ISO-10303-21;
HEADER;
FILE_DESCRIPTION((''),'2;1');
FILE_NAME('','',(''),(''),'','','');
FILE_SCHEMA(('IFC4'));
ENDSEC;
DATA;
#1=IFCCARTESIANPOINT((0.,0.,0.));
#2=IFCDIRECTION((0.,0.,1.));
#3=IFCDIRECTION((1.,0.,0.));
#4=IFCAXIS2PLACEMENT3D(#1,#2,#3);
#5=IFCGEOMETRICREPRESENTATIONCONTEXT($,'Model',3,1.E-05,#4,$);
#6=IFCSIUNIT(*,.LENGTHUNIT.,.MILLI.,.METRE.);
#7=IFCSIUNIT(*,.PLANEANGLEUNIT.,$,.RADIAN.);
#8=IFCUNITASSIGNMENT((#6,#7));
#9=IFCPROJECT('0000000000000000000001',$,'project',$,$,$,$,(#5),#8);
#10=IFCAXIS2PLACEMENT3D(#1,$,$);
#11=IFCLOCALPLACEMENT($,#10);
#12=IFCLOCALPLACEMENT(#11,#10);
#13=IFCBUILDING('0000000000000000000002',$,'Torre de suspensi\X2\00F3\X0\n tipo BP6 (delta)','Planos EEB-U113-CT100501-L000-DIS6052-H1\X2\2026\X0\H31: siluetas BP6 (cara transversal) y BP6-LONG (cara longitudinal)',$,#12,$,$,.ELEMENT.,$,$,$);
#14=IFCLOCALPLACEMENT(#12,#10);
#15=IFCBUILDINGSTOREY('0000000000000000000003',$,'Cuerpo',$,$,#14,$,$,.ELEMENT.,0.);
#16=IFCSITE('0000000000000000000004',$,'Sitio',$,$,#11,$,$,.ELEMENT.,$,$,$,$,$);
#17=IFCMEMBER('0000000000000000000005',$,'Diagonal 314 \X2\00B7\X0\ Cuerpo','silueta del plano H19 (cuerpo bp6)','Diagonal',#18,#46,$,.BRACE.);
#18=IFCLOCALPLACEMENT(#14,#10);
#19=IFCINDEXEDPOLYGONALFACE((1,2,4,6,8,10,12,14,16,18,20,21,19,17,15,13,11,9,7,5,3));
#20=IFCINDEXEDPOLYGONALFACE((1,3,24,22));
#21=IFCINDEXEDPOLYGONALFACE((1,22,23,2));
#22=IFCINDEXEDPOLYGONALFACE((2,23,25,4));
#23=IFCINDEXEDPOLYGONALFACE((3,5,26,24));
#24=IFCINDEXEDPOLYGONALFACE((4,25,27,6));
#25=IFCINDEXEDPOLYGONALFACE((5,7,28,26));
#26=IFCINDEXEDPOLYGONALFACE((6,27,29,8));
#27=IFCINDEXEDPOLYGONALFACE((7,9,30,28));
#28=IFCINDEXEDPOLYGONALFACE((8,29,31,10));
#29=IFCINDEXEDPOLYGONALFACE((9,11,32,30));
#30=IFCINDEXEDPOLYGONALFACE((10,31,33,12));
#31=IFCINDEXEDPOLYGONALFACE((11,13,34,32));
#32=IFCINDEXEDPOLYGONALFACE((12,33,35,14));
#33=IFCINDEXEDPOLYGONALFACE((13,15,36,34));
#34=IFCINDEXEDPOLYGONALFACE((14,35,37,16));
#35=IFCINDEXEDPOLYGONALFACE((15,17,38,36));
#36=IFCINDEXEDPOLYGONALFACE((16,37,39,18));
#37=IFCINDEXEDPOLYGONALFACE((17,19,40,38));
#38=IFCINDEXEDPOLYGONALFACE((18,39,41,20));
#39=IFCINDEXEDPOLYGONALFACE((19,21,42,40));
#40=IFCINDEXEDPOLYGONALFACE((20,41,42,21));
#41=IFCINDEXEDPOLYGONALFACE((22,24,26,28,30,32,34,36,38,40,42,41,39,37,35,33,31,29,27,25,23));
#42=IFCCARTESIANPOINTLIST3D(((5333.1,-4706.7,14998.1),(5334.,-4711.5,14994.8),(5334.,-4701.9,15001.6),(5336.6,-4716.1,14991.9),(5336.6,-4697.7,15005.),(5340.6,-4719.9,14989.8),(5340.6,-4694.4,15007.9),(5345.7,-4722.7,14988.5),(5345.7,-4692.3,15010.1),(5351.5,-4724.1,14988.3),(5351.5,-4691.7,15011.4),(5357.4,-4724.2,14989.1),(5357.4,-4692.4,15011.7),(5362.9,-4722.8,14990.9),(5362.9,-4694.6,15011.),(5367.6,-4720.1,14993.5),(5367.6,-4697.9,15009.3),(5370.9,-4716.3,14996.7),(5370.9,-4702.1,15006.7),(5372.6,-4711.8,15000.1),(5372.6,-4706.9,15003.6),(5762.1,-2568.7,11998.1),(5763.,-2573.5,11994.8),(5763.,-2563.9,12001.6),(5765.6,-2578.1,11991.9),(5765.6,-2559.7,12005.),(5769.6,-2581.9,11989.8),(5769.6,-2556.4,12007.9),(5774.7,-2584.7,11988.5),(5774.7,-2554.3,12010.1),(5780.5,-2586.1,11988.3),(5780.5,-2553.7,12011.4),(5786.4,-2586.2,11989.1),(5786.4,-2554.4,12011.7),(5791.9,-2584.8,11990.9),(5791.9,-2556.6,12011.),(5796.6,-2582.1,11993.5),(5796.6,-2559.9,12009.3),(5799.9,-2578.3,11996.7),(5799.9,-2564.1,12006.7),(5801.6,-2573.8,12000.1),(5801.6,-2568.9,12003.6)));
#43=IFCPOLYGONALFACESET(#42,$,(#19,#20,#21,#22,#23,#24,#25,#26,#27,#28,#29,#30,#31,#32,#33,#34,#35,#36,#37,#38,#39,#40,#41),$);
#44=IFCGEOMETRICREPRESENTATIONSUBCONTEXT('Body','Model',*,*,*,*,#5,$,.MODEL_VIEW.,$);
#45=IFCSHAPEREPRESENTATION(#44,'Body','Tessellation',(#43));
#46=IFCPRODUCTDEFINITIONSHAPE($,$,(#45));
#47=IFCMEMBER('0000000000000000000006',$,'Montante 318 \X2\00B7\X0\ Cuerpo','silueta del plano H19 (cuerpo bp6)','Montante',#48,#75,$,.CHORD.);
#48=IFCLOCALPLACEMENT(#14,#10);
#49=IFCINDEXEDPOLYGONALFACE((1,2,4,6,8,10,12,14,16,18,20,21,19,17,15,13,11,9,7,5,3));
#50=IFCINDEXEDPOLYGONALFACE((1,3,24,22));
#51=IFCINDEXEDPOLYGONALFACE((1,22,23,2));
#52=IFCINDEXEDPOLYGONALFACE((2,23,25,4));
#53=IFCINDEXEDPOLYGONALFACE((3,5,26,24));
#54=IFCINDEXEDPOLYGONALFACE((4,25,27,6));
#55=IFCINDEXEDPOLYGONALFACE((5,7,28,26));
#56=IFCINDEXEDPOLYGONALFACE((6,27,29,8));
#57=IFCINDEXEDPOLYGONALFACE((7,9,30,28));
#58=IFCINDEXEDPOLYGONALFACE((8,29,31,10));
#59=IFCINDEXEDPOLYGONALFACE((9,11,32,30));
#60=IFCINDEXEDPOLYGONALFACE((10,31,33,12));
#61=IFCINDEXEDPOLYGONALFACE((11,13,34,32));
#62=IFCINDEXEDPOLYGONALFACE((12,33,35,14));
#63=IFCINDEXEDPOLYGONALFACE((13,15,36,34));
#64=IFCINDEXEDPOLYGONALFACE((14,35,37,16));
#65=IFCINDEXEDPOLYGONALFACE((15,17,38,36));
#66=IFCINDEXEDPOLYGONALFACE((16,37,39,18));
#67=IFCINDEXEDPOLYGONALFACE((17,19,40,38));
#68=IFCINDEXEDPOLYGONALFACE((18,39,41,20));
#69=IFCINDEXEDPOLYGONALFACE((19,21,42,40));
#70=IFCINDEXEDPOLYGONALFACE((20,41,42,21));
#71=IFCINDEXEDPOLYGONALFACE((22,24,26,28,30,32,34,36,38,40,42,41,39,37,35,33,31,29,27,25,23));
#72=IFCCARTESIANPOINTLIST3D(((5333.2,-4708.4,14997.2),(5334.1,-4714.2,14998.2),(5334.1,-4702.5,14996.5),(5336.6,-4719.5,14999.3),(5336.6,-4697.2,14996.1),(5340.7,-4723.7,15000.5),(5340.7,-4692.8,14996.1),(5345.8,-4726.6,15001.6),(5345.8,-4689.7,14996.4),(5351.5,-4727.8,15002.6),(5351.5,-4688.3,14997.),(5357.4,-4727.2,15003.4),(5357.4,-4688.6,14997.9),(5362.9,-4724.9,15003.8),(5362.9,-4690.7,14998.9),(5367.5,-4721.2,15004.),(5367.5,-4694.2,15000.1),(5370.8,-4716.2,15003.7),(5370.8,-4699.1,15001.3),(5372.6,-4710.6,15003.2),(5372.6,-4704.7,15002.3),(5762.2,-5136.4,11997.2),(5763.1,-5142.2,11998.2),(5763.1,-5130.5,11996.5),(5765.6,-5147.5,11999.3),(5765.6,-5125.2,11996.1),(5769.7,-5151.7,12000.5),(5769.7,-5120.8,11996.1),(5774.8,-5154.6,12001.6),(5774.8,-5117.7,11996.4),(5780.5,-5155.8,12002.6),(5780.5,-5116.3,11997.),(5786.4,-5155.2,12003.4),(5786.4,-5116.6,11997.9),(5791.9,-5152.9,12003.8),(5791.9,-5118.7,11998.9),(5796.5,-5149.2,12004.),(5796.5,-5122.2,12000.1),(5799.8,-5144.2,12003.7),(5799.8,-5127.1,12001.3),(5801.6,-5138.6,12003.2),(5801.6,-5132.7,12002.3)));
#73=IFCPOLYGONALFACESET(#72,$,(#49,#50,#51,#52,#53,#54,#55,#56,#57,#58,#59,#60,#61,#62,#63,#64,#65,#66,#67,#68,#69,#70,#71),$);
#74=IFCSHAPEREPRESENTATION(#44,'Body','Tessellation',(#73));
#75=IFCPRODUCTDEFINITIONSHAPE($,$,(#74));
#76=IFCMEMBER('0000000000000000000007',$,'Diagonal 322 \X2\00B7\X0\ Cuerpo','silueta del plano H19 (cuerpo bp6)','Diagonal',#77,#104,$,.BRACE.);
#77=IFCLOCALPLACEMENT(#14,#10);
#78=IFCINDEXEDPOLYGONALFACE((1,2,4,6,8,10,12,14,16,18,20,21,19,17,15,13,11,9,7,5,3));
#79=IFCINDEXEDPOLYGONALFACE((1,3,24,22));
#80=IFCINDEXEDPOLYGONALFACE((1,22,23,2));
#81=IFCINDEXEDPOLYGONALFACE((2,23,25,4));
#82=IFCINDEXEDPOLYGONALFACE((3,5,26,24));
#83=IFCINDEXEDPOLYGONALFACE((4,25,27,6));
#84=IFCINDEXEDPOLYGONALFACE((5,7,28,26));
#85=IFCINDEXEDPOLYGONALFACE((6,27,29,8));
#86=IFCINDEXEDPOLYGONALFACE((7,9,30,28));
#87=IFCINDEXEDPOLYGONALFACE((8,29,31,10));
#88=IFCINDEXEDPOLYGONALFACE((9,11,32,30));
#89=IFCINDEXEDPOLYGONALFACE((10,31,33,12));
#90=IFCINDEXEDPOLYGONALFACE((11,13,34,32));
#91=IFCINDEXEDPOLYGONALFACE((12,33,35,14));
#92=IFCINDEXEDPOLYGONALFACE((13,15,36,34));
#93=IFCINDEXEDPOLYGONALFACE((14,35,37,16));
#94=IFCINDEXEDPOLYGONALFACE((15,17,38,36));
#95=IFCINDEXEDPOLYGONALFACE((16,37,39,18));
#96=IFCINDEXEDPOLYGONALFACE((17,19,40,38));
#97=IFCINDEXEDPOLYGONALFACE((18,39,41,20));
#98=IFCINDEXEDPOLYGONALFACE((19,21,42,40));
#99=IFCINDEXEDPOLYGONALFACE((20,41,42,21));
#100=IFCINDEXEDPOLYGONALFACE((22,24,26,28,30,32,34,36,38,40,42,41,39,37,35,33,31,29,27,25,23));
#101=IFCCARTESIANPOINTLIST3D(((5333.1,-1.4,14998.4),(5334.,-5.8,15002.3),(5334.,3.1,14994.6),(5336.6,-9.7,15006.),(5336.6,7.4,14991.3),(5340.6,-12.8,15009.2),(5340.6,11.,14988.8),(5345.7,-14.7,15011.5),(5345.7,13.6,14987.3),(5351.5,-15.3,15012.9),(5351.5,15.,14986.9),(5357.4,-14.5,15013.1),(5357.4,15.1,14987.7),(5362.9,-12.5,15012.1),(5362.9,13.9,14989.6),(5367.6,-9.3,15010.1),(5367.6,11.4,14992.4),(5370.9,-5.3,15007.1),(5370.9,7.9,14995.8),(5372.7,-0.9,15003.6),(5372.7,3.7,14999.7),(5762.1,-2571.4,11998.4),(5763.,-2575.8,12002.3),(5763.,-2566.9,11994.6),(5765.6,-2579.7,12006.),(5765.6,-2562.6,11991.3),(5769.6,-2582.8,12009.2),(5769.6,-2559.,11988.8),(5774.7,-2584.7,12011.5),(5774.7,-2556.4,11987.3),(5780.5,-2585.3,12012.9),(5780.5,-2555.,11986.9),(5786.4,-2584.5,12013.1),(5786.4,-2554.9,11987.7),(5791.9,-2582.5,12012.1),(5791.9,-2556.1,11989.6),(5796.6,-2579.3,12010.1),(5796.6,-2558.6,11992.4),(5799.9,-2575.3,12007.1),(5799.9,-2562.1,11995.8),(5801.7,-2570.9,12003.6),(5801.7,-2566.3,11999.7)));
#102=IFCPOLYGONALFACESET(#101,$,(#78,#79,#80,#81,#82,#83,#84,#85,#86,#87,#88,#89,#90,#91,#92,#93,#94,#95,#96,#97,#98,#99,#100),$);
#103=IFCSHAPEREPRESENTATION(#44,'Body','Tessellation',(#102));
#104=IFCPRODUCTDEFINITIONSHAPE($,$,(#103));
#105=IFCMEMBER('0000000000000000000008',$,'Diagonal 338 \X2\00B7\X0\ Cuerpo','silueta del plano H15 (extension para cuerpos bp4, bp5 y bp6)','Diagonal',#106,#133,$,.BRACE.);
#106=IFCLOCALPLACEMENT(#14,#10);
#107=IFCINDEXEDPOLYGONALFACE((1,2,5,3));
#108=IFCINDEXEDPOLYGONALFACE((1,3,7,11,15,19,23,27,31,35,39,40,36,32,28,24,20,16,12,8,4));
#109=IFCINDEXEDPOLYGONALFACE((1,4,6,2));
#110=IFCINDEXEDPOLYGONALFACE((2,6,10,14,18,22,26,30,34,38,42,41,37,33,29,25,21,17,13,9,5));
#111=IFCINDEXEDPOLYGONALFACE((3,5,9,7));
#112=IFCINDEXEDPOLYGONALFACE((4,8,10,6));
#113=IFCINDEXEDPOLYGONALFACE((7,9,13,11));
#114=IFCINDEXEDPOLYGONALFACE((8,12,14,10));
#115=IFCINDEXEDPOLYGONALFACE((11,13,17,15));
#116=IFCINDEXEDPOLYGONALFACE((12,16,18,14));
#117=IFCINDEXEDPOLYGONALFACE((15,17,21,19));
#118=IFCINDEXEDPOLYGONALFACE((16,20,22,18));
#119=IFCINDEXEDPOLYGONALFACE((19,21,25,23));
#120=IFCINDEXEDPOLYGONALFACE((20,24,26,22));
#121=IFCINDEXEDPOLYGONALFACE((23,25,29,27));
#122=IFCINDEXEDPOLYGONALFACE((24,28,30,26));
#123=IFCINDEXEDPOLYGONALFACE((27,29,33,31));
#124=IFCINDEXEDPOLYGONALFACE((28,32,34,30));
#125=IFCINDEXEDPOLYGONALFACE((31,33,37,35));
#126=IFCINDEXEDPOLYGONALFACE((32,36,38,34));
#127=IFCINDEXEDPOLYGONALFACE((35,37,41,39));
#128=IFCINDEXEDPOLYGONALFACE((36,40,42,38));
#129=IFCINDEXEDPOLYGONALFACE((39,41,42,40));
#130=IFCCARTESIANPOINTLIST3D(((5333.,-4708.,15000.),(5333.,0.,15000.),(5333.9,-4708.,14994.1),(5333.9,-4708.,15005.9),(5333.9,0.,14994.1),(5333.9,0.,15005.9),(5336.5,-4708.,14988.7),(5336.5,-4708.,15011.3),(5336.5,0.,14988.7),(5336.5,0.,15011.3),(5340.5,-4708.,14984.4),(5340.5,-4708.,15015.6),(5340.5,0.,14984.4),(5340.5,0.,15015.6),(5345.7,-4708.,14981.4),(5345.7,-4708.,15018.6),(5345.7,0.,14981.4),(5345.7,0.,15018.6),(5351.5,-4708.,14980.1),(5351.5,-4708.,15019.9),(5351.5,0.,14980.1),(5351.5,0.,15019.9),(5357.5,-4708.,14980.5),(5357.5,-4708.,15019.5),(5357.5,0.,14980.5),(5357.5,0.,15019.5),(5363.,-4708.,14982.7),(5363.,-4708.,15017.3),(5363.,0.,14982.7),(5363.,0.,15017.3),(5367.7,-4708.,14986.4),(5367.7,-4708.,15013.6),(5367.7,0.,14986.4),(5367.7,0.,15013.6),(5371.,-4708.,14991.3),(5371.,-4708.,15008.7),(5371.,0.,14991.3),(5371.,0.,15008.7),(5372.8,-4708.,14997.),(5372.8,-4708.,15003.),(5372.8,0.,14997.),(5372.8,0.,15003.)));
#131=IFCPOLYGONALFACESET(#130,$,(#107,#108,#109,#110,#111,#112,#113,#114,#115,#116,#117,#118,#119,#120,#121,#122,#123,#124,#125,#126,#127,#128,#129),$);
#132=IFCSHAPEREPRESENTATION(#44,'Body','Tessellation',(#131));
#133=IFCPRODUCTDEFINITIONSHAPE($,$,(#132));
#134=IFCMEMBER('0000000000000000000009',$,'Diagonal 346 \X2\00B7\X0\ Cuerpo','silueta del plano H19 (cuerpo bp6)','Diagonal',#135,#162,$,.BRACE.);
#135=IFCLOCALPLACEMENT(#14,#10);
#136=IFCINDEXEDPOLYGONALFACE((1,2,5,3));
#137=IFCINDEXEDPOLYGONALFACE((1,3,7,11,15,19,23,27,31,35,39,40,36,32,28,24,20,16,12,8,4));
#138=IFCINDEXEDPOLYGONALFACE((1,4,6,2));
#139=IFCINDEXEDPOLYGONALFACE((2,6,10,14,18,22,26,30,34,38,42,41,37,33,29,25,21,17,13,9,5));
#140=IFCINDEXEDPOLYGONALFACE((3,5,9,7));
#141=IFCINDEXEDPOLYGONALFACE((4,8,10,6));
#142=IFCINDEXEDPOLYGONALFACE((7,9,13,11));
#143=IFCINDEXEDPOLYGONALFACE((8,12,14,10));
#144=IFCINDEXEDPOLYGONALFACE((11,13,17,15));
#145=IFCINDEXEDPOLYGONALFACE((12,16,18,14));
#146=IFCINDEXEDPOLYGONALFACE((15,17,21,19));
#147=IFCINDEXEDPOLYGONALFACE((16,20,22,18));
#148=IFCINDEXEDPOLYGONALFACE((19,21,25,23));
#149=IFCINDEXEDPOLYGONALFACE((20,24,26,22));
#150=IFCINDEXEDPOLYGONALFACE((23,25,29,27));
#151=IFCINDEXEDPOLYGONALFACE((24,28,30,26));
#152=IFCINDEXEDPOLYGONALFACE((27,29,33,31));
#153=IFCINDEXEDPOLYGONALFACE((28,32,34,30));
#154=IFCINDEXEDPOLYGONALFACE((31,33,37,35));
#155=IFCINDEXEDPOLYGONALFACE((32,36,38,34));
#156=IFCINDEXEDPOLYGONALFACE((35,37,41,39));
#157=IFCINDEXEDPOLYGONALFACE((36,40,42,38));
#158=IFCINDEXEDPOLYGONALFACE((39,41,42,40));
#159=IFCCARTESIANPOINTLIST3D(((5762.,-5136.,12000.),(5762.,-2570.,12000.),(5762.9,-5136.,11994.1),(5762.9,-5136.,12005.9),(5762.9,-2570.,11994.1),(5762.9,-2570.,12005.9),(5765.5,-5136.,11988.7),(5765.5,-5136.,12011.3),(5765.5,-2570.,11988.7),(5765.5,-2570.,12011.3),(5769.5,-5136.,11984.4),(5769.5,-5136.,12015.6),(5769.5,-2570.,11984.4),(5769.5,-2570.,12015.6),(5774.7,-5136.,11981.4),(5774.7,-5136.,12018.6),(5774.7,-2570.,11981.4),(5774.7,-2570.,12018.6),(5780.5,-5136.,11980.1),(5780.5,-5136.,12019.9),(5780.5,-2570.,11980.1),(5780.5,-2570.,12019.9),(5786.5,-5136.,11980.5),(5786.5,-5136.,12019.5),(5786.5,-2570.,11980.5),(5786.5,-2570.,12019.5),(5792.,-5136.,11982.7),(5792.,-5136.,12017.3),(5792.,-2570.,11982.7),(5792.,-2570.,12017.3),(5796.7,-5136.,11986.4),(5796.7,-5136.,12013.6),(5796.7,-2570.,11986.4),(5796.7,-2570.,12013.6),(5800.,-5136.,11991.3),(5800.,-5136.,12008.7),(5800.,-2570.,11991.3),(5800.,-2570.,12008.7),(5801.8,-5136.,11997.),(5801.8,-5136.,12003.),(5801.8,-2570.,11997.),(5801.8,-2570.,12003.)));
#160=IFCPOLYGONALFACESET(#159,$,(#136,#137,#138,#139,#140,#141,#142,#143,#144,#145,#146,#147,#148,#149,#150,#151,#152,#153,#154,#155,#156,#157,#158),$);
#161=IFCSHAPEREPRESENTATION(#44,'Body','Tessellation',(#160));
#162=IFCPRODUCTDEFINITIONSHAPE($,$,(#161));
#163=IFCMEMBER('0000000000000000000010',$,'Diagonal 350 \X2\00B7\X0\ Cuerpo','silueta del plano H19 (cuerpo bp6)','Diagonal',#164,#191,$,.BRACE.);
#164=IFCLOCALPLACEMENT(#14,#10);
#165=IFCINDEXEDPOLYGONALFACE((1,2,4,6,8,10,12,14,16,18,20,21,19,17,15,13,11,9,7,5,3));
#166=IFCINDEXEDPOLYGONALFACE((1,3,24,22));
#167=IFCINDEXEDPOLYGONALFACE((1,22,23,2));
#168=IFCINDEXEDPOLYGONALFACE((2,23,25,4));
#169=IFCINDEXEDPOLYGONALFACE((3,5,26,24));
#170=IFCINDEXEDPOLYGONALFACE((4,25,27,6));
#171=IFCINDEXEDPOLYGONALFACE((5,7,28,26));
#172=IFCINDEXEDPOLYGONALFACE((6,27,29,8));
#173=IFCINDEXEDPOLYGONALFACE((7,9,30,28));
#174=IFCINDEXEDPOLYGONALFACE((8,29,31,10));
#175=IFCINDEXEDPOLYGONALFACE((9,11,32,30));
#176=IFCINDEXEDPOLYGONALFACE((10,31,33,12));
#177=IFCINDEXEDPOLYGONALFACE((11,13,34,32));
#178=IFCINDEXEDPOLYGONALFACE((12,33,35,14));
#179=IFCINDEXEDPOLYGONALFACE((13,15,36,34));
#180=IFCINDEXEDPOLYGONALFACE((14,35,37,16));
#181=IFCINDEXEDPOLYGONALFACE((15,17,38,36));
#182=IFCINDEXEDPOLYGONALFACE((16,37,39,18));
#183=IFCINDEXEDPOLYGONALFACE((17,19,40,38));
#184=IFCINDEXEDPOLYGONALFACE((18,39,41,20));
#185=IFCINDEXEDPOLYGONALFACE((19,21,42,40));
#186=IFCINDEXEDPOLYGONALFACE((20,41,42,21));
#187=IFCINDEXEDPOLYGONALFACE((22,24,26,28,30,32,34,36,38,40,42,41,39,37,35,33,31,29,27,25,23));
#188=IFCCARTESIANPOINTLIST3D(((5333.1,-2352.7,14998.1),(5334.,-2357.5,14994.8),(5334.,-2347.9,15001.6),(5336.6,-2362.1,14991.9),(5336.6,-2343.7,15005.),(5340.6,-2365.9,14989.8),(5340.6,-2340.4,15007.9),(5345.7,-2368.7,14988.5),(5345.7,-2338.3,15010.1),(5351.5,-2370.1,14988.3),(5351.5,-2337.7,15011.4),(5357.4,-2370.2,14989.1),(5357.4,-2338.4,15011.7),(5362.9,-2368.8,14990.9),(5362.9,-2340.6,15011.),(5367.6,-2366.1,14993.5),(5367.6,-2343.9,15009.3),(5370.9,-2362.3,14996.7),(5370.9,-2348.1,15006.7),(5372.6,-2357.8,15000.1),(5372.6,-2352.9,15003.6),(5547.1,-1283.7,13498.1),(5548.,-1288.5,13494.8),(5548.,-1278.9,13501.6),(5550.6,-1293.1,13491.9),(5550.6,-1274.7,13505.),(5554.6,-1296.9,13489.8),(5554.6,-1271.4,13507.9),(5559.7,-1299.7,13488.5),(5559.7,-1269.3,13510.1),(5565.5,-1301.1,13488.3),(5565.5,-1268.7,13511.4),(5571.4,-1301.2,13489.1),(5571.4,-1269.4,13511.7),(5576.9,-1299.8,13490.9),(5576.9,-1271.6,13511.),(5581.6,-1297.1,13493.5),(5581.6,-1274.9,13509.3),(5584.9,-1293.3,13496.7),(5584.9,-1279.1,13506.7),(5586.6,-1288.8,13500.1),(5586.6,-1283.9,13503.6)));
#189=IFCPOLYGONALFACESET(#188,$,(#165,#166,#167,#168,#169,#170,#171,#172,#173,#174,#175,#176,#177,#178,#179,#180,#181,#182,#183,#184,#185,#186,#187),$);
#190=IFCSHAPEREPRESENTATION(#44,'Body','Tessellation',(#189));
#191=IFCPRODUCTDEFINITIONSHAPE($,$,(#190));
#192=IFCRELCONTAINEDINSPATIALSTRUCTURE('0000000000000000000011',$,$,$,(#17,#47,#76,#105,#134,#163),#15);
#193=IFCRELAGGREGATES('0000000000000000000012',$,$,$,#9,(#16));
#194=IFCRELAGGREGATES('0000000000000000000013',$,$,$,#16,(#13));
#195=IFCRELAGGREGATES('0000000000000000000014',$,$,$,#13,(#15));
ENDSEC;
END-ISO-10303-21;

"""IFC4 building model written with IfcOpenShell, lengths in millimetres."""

from ifc_helpers import new_model, si_unit, frame, origin, origin_with_axes, place, context, subcontext, project, spatial, circle, extrude, element, save


model = new_model("IFC4")

# Units and contexts
model_context = context("Model", 3, precision=1e-05, world=origin_with_axes())
body_context = subcontext(model_context, "Body", "Model", "MODEL_VIEW")
ifc_project = project(units=[si_unit("LENGTHUNIT", "METRE", prefix="MILLI"), si_unit("PLANEANGLEUNIT", "RADIAN")], contexts=[model_context])

# Site, building, storey
site_placement = place(None, origin())
site = spatial("IfcSite", under=ifc_project, at=site_placement, Name="Sitio", CompositionType="ELEMENT")
building_placement = place(site_placement, origin())
building = spatial("IfcBuilding", under=site, at=building_placement, Name="Torre de suspensión tipo BP6 (delta)", Description="Planos EEB-U113-CT100501-L000-DIS6052-H1…H31: siluetas BP6 (cara transversal) y BP6-LONG (cara longitudinal)", CompositionType="ELEMENT")
storey_placement = place(building_placement, origin())
storey = spatial("IfcBuildingStorey", under=building, at=storey_placement, Name="Cuerpo", CompositionType="ELEMENT", Elevation=0.0)

# Members
member_1_placement = place(storey_placement, frame((5353.0, -4708.0, 15000.0), z_axis=(0.115671, 0.576469, -0.80889), x_axis=(-0.993288, 0.067132, -0.094198)))
element("IfcMember", 1, at=member_1_placement, inside=storey, Name="Diagonal 314 · Cuerpo", Description="silueta del plano H19 (cuerpo bp6)", ObjectType="Diagonal", PredefinedType="BRACE", context=body_context, shape_type="SweptSolid", body=[
    extrude(circle(Radius=20.0), None, (0.0, 0.0, 1.0), 3708.8),
])
member_2_placement = place(storey_placement, frame((5353.0, -4708.0, 15000.0), z_axis=(0.140169, -0.139842, -0.980202), x_axis=(-0.990128, -0.019797, -0.138764)))
element("IfcMember", 2, at=member_2_placement, inside=storey, Name="Montante 318 · Cuerpo", Description="silueta del plano H19 (cuerpo bp6)", ObjectType="Montante", PredefinedType="CHORD", context=body_context, shape_type="SweptSolid", body=[
    extrude(circle(Radius=20.0), None, (0.0, 0.0, 1.0), 3060.6),
])
member_3_placement = place(storey_placement, frame((5353.0, 0.0, 15000.0), z_axis=(0.107964, -0.64678, -0.754996), x_axis=(-0.994155, -0.07024, -0.081992)))
element("IfcMember", 3, at=member_3_placement, inside=storey, Name="Diagonal 322 · Cuerpo", Description="silueta del plano H19 (cuerpo bp6)", ObjectType="Diagonal", PredefinedType="BRACE", context=body_context, shape_type="SweptSolid", body=[
    extrude(circle(Radius=20.0), None, (0.0, 0.0, 1.0), 3973.5),
])
member_4_placement = place(storey_placement, frame((5353.0, -4708.0, 15000.0), z_axis=(0.0, 1.0, 0.0), x_axis=(-1.0, 0.0, 0.0)))
element("IfcMember", 4, at=member_4_placement, inside=storey, Name="Diagonal 338 · Cuerpo", Description="silueta del plano H15 (extension para cuerpos bp4, bp5 y bp6)", ObjectType="Diagonal", PredefinedType="BRACE", context=body_context, shape_type="SweptSolid", body=[
    extrude(circle(Radius=20.0), None, (0.0, 0.0, 1.0), 4708.0),
])
member_5_placement = place(storey_placement, frame((5782.0, -5136.0, 12000.0), z_axis=(0.0, 1.0, 0.0), x_axis=(-1.0, 0.0, 0.0)))
element("IfcMember", 5, at=member_5_placement, inside=storey, Name="Diagonal 346 · Cuerpo", Description="silueta del plano H19 (cuerpo bp6)", ObjectType="Diagonal", PredefinedType="BRACE", context=body_context, shape_type="SweptSolid", body=[
    extrude(circle(Radius=20.0), None, (0.0, 0.0, 1.0), 2566.0),
])
member_6_placement = place(storey_placement, frame((5353.0, -2354.0, 15000.0), z_axis=(0.115405, 0.576487, -0.808915), x_axis=(-0.993318, 0.066977, -0.093981)))
element("IfcMember", 6, at=member_6_placement, inside=storey, Name="Diagonal 350 · Cuerpo", Description="silueta del plano H19 (cuerpo bp6)", ObjectType="Diagonal", PredefinedType="BRACE", context=body_context, shape_type="SweptSolid", body=[
    extrude(circle(Radius=20.0), None, (0.0, 0.0, 1.0), 1854.3),
])

save(model, "model.ifc")
